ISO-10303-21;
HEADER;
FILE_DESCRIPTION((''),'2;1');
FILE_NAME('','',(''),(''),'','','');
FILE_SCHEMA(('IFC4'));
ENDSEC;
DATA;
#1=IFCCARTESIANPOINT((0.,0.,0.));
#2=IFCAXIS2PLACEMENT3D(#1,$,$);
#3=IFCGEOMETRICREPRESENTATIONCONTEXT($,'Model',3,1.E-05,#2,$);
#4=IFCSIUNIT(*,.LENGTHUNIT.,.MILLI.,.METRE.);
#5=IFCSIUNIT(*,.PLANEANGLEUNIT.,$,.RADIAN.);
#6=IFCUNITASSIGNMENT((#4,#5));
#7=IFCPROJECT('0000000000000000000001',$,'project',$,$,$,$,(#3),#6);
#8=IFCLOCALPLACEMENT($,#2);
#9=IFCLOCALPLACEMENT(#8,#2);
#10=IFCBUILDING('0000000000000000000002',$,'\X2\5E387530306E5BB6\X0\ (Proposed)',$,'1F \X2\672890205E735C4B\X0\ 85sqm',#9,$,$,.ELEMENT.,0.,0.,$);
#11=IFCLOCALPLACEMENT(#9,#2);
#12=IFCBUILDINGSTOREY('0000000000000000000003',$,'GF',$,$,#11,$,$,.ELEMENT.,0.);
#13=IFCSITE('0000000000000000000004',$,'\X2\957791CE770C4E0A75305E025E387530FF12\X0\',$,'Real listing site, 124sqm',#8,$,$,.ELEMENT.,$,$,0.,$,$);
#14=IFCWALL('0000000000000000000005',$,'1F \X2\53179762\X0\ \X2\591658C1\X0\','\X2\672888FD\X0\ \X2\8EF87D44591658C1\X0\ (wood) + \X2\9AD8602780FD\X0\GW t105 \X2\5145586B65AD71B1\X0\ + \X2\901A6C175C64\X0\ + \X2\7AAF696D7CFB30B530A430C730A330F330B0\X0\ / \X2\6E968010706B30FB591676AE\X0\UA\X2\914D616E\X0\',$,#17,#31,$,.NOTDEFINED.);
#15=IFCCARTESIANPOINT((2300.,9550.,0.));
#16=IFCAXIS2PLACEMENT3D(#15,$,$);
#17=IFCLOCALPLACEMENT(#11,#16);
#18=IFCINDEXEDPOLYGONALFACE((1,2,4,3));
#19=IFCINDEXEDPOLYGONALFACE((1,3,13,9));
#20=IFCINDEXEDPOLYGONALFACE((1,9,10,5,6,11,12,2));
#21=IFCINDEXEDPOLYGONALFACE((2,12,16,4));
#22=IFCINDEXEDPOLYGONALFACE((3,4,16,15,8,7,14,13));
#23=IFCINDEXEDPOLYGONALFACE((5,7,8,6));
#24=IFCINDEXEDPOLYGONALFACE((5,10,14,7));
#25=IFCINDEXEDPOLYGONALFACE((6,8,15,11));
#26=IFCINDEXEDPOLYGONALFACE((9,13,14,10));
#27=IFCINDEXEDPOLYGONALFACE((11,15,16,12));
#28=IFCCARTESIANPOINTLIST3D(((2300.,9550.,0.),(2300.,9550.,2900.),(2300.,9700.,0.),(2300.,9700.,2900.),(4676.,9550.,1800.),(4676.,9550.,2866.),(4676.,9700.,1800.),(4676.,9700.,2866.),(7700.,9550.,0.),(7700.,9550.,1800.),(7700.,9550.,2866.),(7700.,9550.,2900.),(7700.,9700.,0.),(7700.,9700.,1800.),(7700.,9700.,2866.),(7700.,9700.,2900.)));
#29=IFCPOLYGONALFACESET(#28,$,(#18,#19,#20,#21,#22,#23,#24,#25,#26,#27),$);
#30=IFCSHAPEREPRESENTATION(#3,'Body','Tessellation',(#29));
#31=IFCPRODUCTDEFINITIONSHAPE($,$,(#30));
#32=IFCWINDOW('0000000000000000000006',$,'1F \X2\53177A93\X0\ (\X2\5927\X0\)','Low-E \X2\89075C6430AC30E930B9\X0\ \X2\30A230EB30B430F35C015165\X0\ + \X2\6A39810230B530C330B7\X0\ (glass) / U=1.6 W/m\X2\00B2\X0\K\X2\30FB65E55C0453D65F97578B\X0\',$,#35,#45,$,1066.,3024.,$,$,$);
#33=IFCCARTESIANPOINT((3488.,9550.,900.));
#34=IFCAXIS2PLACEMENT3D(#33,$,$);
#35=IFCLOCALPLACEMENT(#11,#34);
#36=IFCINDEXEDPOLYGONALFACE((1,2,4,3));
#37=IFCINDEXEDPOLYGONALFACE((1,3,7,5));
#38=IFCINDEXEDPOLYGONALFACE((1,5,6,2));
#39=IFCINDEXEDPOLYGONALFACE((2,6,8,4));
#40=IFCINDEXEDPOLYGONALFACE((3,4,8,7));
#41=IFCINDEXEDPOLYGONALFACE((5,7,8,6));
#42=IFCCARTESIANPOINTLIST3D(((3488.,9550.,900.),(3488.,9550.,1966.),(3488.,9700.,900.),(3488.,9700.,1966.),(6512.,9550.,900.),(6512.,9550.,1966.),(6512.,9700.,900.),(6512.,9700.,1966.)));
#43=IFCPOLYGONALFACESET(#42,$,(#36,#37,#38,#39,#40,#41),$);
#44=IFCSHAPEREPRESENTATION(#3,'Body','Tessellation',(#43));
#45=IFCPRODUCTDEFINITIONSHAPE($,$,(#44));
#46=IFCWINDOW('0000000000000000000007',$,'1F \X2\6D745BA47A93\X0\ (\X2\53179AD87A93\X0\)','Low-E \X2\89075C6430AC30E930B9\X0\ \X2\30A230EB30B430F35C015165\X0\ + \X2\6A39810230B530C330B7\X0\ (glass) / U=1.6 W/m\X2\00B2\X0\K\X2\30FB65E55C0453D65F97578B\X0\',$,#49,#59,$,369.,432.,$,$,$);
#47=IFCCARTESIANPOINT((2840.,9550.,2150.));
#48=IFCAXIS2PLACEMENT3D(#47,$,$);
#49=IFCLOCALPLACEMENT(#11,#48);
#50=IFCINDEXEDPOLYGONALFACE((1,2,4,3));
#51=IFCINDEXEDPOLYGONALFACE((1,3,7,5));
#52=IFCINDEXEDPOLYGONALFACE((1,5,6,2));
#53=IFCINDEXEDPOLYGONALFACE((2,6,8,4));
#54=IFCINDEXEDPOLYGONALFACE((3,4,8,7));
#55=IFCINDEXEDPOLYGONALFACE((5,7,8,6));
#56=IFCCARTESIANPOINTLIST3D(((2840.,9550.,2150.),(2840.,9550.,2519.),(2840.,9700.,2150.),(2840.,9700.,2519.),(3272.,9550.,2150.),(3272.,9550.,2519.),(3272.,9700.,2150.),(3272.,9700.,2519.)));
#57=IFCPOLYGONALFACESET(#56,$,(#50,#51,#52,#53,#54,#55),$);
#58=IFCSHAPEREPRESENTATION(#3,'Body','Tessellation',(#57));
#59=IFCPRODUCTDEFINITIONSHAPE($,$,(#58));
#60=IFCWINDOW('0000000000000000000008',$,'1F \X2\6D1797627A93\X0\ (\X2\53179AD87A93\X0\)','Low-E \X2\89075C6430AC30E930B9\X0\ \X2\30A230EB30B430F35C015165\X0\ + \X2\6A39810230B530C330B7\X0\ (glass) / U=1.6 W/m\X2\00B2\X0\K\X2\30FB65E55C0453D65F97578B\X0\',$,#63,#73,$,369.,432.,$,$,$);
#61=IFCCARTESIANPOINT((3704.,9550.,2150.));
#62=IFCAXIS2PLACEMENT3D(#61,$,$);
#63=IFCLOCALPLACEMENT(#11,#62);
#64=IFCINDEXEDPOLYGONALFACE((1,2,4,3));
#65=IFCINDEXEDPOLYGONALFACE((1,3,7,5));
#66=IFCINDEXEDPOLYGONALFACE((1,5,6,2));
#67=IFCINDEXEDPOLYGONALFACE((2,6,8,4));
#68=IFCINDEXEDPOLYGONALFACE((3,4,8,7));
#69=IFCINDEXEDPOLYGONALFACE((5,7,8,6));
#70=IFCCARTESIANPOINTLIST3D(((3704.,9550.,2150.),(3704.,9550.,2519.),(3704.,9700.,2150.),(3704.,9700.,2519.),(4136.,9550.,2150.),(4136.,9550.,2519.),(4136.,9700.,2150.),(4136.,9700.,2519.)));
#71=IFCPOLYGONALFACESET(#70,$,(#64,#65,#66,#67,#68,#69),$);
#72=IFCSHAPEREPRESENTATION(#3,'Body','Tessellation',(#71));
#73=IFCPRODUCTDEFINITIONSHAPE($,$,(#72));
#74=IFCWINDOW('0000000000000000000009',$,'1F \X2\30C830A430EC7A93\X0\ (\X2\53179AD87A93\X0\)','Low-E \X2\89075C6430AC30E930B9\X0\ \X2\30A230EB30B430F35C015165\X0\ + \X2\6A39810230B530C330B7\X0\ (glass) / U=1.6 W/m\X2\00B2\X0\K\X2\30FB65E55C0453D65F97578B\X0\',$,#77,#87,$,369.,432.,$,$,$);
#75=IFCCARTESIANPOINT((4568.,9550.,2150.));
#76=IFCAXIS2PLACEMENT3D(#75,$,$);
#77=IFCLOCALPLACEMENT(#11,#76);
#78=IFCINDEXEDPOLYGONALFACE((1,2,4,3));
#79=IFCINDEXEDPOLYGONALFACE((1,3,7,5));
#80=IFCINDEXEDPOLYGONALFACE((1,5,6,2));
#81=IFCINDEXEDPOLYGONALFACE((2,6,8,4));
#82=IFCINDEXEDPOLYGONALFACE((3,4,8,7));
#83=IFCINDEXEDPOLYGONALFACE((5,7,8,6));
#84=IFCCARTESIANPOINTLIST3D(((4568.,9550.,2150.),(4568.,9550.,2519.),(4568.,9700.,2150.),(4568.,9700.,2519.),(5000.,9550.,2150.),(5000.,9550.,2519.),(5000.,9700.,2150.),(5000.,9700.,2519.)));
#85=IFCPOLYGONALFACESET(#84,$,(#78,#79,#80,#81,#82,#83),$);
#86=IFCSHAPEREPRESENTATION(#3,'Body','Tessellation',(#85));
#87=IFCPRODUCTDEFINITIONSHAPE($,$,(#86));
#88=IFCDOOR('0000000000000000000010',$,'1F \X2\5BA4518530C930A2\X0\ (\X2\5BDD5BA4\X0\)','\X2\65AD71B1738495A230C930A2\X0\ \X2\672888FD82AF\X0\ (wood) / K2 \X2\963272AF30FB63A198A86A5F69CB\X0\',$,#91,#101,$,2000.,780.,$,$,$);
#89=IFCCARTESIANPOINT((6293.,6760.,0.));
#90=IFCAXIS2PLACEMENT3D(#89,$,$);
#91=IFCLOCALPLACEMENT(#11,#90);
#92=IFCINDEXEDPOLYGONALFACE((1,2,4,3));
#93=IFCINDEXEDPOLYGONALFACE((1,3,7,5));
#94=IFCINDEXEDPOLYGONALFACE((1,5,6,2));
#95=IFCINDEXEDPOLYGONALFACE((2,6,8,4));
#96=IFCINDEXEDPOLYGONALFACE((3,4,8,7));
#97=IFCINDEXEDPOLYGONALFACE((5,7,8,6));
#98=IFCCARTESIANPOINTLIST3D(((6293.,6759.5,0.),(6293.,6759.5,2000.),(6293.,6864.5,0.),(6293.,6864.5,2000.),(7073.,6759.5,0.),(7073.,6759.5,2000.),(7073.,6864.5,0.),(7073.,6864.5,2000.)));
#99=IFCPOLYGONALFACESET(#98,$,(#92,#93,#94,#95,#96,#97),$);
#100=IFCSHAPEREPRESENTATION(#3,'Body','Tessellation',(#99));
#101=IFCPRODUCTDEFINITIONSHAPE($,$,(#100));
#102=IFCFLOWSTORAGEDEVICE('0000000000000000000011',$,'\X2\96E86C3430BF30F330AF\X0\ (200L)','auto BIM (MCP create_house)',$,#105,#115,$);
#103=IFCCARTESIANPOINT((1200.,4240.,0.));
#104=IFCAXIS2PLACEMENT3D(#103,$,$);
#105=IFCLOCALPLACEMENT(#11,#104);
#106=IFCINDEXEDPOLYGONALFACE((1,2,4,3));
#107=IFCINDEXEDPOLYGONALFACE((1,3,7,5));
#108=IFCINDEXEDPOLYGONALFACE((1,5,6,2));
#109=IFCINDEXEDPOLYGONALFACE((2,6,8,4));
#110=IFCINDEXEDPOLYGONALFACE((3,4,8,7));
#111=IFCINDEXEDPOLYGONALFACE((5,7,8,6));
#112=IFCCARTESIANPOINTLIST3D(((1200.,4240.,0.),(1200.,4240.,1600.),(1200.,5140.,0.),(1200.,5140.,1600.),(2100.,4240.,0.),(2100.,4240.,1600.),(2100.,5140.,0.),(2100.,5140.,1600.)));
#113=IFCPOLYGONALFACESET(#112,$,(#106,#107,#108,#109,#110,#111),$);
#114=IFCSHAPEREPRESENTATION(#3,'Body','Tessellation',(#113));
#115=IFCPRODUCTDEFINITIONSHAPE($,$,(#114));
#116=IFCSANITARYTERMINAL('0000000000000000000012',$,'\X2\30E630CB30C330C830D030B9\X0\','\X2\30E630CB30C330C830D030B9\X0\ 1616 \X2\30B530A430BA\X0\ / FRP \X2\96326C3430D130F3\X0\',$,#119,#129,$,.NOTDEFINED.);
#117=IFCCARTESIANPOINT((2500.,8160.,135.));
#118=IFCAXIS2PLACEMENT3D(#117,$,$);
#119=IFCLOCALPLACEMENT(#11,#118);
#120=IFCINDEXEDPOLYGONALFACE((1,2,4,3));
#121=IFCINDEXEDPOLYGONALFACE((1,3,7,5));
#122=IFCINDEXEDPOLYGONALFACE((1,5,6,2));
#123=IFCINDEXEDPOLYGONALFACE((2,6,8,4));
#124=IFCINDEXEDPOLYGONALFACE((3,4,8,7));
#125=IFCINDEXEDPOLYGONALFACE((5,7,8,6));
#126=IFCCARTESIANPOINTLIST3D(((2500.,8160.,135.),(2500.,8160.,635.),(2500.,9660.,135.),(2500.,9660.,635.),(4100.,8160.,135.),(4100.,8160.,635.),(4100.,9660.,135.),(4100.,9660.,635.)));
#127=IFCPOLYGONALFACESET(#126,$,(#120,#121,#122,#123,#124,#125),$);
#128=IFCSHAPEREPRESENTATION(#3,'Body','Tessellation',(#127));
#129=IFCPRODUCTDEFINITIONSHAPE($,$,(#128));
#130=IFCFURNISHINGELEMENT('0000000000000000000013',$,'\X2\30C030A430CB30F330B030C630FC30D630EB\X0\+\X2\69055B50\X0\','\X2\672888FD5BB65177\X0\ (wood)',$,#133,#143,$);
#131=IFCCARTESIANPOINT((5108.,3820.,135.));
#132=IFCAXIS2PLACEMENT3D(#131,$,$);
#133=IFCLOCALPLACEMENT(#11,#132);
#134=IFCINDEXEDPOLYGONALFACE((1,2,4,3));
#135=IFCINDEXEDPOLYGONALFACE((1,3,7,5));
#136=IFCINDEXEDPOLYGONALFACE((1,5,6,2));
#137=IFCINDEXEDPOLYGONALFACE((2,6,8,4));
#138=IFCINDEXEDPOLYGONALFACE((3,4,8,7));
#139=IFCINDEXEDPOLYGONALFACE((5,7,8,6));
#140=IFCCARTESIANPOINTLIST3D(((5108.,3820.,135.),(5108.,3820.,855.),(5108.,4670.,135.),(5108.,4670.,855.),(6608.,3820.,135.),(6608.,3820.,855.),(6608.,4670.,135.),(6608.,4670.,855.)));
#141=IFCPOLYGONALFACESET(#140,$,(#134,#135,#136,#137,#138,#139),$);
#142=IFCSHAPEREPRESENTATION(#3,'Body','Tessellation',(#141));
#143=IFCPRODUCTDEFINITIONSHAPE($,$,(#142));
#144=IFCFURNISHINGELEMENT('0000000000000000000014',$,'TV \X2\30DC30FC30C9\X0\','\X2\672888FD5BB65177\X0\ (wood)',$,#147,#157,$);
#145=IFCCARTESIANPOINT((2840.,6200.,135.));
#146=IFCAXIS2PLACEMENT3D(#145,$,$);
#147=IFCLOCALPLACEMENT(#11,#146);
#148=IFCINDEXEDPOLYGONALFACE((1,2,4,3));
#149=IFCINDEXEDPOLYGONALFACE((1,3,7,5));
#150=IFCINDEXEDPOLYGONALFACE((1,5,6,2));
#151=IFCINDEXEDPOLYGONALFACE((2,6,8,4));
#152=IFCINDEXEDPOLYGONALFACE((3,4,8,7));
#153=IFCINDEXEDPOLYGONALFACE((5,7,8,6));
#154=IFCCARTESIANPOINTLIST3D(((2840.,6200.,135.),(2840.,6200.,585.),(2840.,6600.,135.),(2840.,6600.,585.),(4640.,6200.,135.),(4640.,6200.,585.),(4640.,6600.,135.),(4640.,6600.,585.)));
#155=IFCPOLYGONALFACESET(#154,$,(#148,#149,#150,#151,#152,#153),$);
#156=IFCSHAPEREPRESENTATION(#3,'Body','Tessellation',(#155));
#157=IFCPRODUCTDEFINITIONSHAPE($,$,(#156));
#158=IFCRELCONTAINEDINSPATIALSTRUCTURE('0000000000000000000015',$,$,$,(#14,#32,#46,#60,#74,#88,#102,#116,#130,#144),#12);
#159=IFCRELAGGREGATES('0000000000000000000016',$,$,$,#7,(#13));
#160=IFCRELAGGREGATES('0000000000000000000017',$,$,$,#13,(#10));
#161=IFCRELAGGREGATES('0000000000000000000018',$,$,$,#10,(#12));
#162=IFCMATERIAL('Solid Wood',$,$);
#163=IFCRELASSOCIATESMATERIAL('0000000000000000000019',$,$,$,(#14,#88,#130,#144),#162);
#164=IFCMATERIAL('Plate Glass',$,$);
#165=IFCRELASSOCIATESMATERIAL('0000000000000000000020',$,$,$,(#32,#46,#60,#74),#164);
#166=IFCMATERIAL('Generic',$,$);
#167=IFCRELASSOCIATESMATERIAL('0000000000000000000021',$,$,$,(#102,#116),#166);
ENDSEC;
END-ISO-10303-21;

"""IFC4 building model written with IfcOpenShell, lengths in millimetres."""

from ifc_helpers import new_model, si_unit, frame, frame_2d, origin, place, context, project, spatial, rectangle, extrude, material, element, fill, save


model = new_model("IFC4")

# Units and contexts
model_context = context("Model", 3, precision=1e-05, world=origin())
ifc_project = project(units=[si_unit("LENGTHUNIT", "METRE", prefix="MILLI"), si_unit("PLANEANGLEUNIT", "RADIAN")], contexts=[model_context])

# Site, building, storey
site_placement = place(None, origin())
site = spatial("IfcSite", under=ifc_project, at=site_placement, Name="長野県上田市常田２", ObjectType="Real listing site, 124sqm", CompositionType="ELEMENT", RefElevation=0.0)
building_placement = place(site_placement, origin())
building = spatial("IfcBuilding", under=site, at=building_placement, Name="常田の家 (Proposed)", ObjectType="1F 木造平屋 85sqm", CompositionType="ELEMENT", ElevationOfRefHeight=0.0, ElevationOfTerrain=0.0)
storey_placement = place(building_placement, origin())
storey = spatial("IfcBuildingStorey", under=building, at=storey_placement, Name="GF", CompositionType="ELEMENT", Elevation=0.0)

# Wall, openings, windows
ifc_material_1 = material(Name="Solid Wood")
wall_1_placement = place(storey_placement, frame((2300.0, 9550.0, 0.0)))
wall_1 = element("IfcWall", 1, at=wall_1_placement, inside=storey, material=ifc_material_1, Name="1F 北面 外壁", Description="木製 軸組外壁 (wood) + 高性能GW t105 充填断熱 + 通気層 + 窯業系サイディング / 準耐火・外皮UA配慮", PredefinedType="NOTDEFINED", context=model_context, shape_type="SweptSolid", body=[
    extrude(rectangle(XDim=5400.0, YDim=150.0, at=frame_2d((2700.0, 75.0))), frame((2300.0, 9550.0, 0.0)), (0.0, 0.0, 1.0), 2900.0),
])
opening_1_placement = place(storey_placement, frame((3488.0, 9550.0, 900.0)))
opening_1 = element("IfcOpeningElement", 2, at=opening_1_placement, cuts=wall_1, PredefinedType="NOTDEFINED", context=model_context, shape_type="SweptSolid", body=[
    extrude(rectangle(XDim=3024.0, YDim=150.0, at=frame_2d((1512.0, 75.0))), frame((3488.0, 9550.0, 900.0)), (0.0, 0.0, 1.0), 1066.0),
])
opening_2_placement = place(storey_placement, frame((2840.0, 9550.0, 2150.0)))
opening_2 = element("IfcOpeningElement", 3, at=opening_2_placement, cuts=wall_1, PredefinedType="NOTDEFINED", context=model_context, shape_type="SweptSolid", body=[
    extrude(rectangle(XDim=432.0, YDim=150.0, at=frame_2d((216.0, 75.0))), frame((2840.0, 9550.0, 2150.0)), (0.0, 0.0, 1.0), 369.0),
])
opening_3_placement = place(storey_placement, frame((3704.0, 9550.0, 2150.0)))
opening_3 = element("IfcOpeningElement", 4, at=opening_3_placement, cuts=wall_1, PredefinedType="NOTDEFINED", context=model_context, shape_type="SweptSolid", body=[
    extrude(rectangle(XDim=432.0, YDim=150.0, at=frame_2d((216.0, 75.0))), frame((3704.0, 9550.0, 2150.0)), (0.0, 0.0, 1.0), 369.0),
])
opening_4_placement = place(storey_placement, frame((4568.0, 9550.0, 2150.0)))
opening_4 = element("IfcOpeningElement", 5, at=opening_4_placement, cuts=wall_1, PredefinedType="NOTDEFINED", context=model_context, shape_type="SweptSolid", body=[
    extrude(rectangle(XDim=432.0, YDim=150.0, at=frame_2d((216.0, 75.0))), frame((4568.0, 9550.0, 2150.0)), (0.0, 0.0, 1.0), 369.0),
])
ifc_material_2 = material(Name="Plate Glass")
window_1_placement = place(storey_placement, frame((3488.0, 9550.0, 900.0)))
window_1 = element("IfcWindow", 6, at=window_1_placement, inside=storey, material=ifc_material_2, Name="1F 北窓 (大)", Description="Low-E 複層ガラス アルゴン封入 + 樹脂サッシ (glass) / U=1.6 W/m²K・日射取得型", OverallHeight=1066.0, OverallWidth=3024.0, context=model_context, shape_type="SweptSolid", body=[
    extrude(rectangle(XDim=3024.0, YDim=150.0, at=frame_2d((1512.0, 75.0))), frame((3488.0, 9550.0, 900.0)), (0.0, 0.0, 1.0), 1066.0),
])
fill(opening_1, window_1)
window_2_placement = place(storey_placement, frame((2840.0, 9550.0, 2150.0)))
window_2 = element("IfcWindow", 7, at=window_2_placement, inside=storey, material=ifc_material_2, Name="1F 浴室窓 (北高窓)", Description="Low-E 複層ガラス アルゴン封入 + 樹脂サッシ (glass) / U=1.6 W/m²K・日射取得型", OverallHeight=369.0, OverallWidth=432.0, context=model_context, shape_type="SweptSolid", body=[
    extrude(rectangle(XDim=432.0, YDim=150.0, at=frame_2d((216.0, 75.0))), frame((2840.0, 9550.0, 2150.0)), (0.0, 0.0, 1.0), 369.0),
])
fill(opening_2, window_2)
window_3_placement = place(storey_placement, frame((3704.0, 9550.0, 2150.0)))
window_3 = element("IfcWindow", 8, at=window_3_placement, inside=storey, material=ifc_material_2, Name="1F 洗面窓 (北高窓)", Description="Low-E 複層ガラス アルゴン封入 + 樹脂サッシ (glass) / U=1.6 W/m²K・日射取得型", OverallHeight=369.0, OverallWidth=432.0, context=model_context, shape_type="SweptSolid", body=[
    extrude(rectangle(XDim=432.0, YDim=150.0, at=frame_2d((216.0, 75.0))), frame((3704.0, 9550.0, 2150.0)), (0.0, 0.0, 1.0), 369.0),
])
fill(opening_3, window_3)
window_4_placement = place(storey_placement, frame((4568.0, 9550.0, 2150.0)))
window_4 = element("IfcWindow", 9, at=window_4_placement, inside=storey, material=ifc_material_2, Name="1F トイレ窓 (北高窓)", Description="Low-E 複層ガラス アルゴン封入 + 樹脂サッシ (glass) / U=1.6 W/m²K・日射取得型", OverallHeight=369.0, OverallWidth=432.0, context=model_context, shape_type="SweptSolid", body=[
    extrude(rectangle(XDim=432.0, YDim=150.0, at=frame_2d((216.0, 75.0))), frame((4568.0, 9550.0, 2150.0)), (0.0, 0.0, 1.0), 369.0),
])
fill(opening_4, window_4)

# Door
door_1_placement = place(storey_placement, frame((6293.0, 6760.0, 0.0)))
element("IfcDoor", 10, at=door_1_placement, inside=storey, material=ifc_material_1, Name="1F 室内ドア (寝室)", Description="断熱玄関ドア 木製芯 (wood) / K2 防犯・採風機構", OverallHeight=2000.0, OverallWidth=780.0, context=model_context, shape_type="SweptSolid", body=[
    extrude(rectangle(XDim=780.0, YDim=105.0, at=frame_2d((390.0, 52.0))), frame((6293.0, 6760.0, 0.0)), (0.0, 0.0, 1.0), 2000.0),
])

# Flow storage device
ifc_material_3 = material(Name="Generic")
flow_storage_device_placement = place(storey_placement, frame((1200.0, 4240.0, 0.0)))
element("IfcFlowStorageDevice", 11, at=flow_storage_device_placement, inside=storey, material=ifc_material_3, Name="雨水タンク (200L)", Description="auto BIM (MCP create_house)", context=model_context, shape_type="SweptSolid", body=[
    extrude(rectangle(XDim=900.0, YDim=900.0, at=frame_2d((450.0, 450.0))), frame((1200.0, 4240.0, 0.0)), (0.0, 0.0, 1.0), 1600.0),
])

# Sanitary terminal
sanitary_terminal_placement = place(storey_placement, frame((2500.0, 8160.0, 135.0)))
element("IfcSanitaryTerminal", 12, at=sanitary_terminal_placement, inside=storey, material=ifc_material_3, Name="ユニットバス", Description="ユニットバス 1616 サイズ / FRP 防水パン", PredefinedType="NOTDEFINED", context=model_context, shape_type="SweptSolid", body=[
    extrude(rectangle(XDim=1600.0, YDim=1500.0, at=frame_2d((800.0, 750.0))), frame((2500.0, 8160.0, 135.0)), (0.0, 0.0, 1.0), 500.0),
])

# Furnishing elements
furnishing_1_placement = place(storey_placement, frame((5108.0, 3820.0, 135.0)))
element("IfcFurnishingElement", 13, at=furnishing_1_placement, inside=storey, material=ifc_material_1, Name="ダイニングテーブル+椅子", Description="木製家具 (wood)", context=model_context, shape_type="SweptSolid", body=[
    extrude(rectangle(XDim=1500.0, YDim=850.0, at=frame_2d((750.0, 425.0))), frame((5108.0, 3820.0, 135.0)), (0.0, 0.0, 1.0), 720.0),
])
furnishing_2_placement = place(storey_placement, frame((2840.0, 6200.0, 135.0)))
element("IfcFurnishingElement", 14, at=furnishing_2_placement, inside=storey, material=ifc_material_1, Name="TV ボード", Description="木製家具 (wood)", context=model_context, shape_type="SweptSolid", body=[
    extrude(rectangle(XDim=1800.0, YDim=400.0, at=frame_2d((900.0, 200.0))), frame((2840.0, 6200.0, 135.0)), (0.0, 0.0, 1.0), 450.0),
])

save(model, "model.ifc")
